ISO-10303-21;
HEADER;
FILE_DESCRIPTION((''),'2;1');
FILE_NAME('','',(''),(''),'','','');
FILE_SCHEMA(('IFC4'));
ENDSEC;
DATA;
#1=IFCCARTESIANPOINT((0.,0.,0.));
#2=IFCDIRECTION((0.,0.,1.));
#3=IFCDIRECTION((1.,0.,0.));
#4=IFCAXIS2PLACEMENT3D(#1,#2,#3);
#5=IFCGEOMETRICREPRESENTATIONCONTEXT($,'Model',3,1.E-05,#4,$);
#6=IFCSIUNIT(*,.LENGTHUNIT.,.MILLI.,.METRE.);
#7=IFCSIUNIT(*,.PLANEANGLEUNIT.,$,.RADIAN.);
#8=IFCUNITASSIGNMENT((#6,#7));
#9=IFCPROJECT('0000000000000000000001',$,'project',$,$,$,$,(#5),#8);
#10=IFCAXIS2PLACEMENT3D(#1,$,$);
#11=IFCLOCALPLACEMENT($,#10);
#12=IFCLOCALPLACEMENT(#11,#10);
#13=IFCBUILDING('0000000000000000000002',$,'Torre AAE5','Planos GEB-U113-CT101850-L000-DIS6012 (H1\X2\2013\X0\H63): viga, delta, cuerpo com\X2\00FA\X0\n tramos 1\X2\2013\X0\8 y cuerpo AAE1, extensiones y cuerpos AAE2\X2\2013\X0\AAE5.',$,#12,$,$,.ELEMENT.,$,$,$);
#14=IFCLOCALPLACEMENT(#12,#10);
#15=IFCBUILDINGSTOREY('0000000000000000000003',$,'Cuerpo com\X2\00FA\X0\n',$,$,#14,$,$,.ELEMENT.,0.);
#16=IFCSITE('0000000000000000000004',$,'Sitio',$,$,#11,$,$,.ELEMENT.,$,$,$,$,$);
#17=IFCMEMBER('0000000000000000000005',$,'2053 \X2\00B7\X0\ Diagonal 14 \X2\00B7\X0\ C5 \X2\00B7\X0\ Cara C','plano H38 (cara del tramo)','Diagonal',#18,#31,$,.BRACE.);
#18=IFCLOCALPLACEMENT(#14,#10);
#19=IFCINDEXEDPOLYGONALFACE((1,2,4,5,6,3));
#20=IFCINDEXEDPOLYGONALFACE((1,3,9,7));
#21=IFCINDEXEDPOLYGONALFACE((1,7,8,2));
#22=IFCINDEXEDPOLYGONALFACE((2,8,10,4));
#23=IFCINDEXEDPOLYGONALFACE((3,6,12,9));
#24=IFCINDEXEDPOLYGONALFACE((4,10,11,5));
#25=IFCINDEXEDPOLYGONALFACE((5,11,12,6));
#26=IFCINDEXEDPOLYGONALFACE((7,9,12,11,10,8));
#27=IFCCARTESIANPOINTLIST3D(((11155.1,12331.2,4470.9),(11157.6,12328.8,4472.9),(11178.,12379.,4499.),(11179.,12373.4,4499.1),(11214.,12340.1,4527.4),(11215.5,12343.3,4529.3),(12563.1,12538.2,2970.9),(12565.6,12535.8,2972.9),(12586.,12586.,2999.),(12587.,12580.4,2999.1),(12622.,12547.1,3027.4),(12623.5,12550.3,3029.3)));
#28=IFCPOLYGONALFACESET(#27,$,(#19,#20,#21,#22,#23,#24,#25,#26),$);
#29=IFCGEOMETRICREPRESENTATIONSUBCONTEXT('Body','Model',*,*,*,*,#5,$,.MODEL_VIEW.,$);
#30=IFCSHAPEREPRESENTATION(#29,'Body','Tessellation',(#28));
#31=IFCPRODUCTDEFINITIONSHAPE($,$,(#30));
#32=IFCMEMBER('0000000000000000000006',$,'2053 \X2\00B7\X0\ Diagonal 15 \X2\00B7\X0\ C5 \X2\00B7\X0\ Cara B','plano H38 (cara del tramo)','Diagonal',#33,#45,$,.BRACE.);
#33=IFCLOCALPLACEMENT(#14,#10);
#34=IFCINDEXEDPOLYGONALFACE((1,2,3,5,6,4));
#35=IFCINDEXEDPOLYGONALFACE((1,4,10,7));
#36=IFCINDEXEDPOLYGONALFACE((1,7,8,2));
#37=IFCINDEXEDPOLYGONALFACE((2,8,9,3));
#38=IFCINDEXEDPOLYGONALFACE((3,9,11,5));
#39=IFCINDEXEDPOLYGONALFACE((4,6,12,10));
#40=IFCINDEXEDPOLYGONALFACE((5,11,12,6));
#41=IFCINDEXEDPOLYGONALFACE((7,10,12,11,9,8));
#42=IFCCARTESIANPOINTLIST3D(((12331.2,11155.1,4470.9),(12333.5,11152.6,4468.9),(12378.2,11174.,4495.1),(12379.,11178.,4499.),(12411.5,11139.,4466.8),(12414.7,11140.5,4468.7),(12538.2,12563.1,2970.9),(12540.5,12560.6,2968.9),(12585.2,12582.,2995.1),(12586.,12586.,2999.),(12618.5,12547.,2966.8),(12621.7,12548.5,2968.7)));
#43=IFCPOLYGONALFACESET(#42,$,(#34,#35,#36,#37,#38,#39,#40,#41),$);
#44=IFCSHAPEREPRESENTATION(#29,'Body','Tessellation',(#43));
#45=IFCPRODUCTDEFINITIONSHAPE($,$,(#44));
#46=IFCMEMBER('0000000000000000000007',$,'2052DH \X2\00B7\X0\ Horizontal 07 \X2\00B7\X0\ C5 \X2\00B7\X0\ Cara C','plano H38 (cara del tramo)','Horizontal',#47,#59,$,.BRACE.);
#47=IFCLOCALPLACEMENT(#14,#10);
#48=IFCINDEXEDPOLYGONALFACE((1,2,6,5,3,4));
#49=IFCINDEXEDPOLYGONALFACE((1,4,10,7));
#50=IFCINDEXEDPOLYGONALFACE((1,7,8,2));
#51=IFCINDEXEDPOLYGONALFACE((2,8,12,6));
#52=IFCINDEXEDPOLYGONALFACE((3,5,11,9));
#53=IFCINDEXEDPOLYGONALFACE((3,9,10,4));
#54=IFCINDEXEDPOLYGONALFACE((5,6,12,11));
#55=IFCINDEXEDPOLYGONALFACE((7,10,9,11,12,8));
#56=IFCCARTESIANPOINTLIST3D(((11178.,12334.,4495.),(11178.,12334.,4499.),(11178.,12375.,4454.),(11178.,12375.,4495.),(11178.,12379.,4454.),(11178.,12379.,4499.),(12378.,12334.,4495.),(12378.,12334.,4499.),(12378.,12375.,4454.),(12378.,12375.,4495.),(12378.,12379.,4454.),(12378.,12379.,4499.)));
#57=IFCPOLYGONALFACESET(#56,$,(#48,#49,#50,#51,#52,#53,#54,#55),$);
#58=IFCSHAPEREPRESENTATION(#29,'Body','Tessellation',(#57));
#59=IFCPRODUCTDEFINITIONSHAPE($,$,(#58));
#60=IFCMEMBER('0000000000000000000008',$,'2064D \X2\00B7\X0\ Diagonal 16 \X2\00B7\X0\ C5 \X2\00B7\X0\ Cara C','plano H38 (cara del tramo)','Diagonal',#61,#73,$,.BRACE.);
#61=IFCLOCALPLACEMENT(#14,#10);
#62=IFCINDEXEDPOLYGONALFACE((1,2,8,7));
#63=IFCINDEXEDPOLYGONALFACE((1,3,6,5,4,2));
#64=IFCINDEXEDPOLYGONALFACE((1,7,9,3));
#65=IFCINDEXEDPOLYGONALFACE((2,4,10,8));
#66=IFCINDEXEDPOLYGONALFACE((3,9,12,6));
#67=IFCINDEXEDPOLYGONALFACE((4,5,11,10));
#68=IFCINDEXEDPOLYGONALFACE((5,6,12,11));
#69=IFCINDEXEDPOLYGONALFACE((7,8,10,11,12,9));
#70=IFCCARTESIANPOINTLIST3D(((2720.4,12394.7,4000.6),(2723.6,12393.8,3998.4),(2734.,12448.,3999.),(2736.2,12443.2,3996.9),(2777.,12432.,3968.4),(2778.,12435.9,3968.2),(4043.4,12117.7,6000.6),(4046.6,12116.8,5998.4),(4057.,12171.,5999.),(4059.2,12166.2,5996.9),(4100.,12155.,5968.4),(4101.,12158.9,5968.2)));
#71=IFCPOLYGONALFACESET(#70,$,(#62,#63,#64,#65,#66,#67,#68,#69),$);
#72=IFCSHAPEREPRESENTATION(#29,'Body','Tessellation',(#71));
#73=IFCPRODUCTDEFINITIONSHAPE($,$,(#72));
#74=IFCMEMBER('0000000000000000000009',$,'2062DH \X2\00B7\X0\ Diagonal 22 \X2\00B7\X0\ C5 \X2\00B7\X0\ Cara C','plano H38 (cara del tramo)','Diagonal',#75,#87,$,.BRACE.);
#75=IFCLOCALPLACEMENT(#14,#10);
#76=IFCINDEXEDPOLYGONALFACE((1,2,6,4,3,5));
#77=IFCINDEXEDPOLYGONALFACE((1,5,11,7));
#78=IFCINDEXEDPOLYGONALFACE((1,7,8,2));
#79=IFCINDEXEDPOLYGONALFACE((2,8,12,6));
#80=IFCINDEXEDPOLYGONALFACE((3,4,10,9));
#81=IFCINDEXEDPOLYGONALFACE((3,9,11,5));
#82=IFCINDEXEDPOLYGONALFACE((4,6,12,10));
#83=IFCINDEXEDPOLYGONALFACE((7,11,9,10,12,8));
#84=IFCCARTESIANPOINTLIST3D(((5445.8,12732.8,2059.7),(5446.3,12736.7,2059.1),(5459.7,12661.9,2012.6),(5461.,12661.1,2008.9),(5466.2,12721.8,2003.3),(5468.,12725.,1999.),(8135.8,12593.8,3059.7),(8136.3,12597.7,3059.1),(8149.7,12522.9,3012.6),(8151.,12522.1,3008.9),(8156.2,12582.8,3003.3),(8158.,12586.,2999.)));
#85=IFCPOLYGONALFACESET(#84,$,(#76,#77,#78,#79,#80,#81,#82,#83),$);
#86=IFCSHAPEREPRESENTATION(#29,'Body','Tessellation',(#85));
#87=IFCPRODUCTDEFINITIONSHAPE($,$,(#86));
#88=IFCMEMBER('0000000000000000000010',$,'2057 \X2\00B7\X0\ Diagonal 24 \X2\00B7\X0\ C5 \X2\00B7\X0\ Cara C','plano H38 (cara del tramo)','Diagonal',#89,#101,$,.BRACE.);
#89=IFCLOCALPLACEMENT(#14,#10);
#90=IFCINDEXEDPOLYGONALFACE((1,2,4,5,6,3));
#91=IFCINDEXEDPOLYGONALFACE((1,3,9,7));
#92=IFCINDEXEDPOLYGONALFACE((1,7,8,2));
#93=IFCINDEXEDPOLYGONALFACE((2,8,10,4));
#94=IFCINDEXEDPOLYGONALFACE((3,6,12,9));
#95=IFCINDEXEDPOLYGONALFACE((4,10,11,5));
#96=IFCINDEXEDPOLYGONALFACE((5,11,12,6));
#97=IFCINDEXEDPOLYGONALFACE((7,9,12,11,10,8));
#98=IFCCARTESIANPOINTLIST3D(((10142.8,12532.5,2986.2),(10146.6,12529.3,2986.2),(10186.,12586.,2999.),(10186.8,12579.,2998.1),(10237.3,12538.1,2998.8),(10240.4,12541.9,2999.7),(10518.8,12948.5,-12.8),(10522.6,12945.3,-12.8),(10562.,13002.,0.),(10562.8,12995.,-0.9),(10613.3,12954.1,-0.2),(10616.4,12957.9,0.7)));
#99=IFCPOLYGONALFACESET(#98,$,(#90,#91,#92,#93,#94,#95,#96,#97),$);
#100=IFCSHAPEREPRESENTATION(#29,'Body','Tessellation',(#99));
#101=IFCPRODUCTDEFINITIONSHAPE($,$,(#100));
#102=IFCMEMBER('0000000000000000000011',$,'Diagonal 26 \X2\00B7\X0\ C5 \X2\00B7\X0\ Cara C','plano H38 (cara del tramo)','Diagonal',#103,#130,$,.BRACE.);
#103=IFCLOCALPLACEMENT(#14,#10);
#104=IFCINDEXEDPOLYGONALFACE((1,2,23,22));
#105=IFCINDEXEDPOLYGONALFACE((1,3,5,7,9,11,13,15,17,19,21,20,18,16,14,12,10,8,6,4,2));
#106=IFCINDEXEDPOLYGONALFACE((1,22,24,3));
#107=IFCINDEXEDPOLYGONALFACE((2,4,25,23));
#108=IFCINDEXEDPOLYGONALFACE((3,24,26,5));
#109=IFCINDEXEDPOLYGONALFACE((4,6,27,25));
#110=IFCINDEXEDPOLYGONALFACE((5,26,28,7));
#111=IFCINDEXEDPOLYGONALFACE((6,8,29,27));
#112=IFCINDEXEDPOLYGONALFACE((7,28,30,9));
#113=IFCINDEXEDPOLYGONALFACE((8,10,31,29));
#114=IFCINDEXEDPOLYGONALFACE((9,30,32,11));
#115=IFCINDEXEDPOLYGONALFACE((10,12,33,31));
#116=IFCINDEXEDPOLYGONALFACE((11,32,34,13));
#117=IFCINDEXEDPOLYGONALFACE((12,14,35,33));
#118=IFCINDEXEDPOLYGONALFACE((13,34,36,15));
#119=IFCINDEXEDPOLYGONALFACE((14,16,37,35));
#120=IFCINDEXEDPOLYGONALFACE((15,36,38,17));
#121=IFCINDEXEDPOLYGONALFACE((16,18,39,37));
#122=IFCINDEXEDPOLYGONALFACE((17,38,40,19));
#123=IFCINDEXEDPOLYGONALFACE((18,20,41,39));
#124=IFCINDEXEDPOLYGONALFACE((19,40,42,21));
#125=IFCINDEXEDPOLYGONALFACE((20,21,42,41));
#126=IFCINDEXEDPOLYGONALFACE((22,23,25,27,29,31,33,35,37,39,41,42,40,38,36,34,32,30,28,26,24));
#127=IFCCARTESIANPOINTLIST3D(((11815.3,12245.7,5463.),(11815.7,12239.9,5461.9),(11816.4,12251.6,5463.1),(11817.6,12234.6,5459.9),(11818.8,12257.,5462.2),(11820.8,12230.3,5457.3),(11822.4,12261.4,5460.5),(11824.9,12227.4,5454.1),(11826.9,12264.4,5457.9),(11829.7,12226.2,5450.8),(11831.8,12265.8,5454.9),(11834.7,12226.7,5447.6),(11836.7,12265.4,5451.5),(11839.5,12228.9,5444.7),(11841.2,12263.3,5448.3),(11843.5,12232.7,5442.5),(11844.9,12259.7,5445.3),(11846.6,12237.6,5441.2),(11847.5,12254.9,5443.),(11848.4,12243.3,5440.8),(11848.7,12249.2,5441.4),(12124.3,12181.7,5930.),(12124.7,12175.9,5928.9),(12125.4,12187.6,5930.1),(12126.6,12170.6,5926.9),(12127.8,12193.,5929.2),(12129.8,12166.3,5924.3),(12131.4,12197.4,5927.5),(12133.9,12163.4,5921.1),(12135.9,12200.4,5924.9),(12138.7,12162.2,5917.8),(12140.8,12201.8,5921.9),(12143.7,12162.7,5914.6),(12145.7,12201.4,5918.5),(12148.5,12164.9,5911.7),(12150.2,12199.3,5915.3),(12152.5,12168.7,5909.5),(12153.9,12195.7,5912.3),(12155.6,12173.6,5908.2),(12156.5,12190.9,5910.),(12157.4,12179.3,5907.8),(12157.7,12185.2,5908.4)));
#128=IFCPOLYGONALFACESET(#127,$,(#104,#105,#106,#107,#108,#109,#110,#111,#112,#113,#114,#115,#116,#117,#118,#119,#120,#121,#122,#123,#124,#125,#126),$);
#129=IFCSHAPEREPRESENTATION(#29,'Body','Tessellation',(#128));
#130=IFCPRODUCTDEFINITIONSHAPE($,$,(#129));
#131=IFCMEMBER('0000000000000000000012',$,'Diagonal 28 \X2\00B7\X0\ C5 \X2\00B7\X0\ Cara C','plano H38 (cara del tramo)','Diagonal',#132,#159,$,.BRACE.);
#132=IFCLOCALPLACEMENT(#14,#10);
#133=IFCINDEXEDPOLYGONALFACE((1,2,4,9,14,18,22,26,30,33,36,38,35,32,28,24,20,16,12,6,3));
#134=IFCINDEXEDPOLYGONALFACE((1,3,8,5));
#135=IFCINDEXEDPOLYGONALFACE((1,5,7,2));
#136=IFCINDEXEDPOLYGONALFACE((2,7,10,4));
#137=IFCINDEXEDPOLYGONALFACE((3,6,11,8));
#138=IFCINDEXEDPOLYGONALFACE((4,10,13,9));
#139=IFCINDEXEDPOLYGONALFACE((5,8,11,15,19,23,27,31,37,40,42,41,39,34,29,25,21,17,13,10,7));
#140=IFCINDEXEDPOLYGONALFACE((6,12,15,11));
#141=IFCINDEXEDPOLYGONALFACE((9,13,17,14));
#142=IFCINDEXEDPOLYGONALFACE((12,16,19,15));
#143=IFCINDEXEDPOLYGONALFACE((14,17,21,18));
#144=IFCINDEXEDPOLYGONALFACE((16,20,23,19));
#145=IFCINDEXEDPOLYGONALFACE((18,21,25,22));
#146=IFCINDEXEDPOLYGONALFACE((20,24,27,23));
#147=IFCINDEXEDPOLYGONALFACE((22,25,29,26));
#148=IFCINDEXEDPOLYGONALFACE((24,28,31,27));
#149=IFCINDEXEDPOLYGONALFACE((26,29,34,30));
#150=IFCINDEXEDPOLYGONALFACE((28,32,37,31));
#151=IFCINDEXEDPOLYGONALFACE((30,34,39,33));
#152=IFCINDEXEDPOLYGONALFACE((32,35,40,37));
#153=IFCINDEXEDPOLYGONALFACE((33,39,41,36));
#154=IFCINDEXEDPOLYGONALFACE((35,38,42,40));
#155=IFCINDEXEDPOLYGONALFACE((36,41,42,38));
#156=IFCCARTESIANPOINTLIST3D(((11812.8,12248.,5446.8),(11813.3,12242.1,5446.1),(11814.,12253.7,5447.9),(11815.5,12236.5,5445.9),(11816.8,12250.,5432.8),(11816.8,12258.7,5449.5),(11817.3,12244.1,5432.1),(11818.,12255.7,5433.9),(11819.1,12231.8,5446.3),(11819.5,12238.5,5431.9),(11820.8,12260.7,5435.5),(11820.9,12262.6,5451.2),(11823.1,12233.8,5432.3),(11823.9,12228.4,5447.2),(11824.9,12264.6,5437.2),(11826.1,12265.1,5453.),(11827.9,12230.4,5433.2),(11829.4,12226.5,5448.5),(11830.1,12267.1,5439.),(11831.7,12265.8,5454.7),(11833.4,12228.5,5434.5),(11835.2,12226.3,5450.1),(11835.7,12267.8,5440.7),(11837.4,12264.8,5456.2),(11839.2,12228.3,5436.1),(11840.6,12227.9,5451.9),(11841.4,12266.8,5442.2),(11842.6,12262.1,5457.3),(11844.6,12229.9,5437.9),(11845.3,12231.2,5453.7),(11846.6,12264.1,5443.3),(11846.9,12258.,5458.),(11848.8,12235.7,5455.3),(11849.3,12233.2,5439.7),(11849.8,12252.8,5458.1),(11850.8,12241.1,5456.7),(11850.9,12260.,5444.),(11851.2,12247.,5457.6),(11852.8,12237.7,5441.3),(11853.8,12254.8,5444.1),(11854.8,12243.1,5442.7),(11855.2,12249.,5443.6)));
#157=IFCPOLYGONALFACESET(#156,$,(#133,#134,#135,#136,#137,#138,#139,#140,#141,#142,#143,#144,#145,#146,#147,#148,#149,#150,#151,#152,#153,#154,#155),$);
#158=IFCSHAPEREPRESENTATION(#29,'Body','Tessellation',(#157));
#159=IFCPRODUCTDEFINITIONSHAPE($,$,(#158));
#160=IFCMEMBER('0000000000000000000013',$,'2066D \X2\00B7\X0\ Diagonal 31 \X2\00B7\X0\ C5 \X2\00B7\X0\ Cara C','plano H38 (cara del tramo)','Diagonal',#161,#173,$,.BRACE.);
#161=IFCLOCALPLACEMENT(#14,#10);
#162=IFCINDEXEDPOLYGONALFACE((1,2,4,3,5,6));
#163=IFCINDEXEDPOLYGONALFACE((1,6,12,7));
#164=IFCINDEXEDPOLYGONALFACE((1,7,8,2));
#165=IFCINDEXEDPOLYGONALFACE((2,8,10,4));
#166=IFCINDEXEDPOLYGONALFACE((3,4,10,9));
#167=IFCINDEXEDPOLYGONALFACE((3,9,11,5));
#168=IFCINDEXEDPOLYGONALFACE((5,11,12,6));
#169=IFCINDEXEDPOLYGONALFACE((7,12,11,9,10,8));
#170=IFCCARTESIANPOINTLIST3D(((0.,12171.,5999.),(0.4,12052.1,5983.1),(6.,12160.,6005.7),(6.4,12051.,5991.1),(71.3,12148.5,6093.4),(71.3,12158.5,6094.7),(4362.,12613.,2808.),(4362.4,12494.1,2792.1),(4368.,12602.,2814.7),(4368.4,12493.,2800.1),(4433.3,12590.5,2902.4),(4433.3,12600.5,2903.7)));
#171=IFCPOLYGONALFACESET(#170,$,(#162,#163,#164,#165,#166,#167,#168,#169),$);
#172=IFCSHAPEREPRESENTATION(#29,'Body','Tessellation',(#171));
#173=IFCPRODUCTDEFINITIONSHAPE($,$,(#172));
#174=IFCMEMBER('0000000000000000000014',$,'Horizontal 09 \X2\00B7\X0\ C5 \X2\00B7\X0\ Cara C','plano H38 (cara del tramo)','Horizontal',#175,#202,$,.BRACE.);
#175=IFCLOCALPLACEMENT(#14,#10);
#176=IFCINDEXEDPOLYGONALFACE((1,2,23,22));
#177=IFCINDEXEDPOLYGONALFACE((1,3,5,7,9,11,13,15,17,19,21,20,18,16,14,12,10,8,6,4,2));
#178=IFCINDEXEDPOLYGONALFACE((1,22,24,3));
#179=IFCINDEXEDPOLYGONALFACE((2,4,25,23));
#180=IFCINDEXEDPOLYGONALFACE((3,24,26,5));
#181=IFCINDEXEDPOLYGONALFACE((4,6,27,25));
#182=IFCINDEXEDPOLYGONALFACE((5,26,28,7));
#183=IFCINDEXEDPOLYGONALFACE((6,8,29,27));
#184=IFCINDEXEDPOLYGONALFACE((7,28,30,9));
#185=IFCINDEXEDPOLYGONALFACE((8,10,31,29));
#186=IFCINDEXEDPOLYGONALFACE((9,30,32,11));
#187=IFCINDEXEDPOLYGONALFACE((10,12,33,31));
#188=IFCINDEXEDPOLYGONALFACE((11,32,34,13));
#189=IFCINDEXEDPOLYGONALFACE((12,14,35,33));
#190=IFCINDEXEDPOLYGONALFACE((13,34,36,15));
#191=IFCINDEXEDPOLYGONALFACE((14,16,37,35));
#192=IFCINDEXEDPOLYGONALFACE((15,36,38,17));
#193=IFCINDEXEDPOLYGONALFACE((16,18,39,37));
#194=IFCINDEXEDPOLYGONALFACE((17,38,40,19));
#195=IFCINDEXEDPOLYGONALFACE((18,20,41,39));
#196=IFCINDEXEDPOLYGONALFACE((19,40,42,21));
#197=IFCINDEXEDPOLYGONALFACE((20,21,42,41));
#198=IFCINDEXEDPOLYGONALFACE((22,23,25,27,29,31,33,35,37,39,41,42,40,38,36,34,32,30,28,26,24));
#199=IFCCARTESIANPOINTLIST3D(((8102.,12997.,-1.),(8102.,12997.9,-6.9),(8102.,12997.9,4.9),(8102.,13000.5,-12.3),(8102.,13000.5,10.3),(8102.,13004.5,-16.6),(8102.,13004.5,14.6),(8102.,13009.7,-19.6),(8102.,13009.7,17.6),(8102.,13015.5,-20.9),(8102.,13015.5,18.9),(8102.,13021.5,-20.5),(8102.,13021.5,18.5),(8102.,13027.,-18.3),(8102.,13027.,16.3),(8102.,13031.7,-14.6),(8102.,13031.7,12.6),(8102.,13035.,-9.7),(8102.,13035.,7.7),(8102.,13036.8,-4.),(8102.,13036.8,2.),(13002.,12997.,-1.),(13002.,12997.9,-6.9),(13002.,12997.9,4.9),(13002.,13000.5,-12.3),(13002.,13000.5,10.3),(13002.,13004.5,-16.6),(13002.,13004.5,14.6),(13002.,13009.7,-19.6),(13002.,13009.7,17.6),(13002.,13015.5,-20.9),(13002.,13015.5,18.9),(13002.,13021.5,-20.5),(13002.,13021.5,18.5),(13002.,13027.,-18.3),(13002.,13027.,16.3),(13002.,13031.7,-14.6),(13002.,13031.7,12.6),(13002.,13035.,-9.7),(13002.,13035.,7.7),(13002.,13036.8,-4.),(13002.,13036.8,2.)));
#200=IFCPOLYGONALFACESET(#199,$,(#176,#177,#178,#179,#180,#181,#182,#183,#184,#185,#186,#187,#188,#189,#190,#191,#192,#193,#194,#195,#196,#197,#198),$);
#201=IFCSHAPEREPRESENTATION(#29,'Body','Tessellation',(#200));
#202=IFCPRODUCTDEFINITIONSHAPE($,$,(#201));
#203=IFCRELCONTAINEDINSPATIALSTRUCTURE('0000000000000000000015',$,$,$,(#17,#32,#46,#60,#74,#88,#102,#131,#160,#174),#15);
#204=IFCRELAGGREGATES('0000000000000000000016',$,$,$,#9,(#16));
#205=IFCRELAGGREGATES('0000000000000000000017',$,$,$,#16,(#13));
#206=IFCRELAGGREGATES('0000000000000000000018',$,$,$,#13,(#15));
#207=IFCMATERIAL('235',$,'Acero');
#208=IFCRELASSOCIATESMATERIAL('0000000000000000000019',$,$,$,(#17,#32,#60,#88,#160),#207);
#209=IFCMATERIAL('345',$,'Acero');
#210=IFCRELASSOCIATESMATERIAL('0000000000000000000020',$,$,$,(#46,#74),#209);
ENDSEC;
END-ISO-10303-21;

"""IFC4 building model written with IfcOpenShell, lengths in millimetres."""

from ifc_helpers import new_model, si_unit, frame, frame_2d, origin, origin_with_axes, place, context, subcontext, project, spatial, circle, l_section, extrude, material, element, save


model = new_model("IFC4")

# Units and contexts
model_context = context("Model", 3, precision=1e-05, world=origin_with_axes())
body_context = subcontext(model_context, "Body", "Model", "MODEL_VIEW")
ifc_project = project(units=[si_unit("LENGTHUNIT", "METRE", prefix="MILLI"), si_unit("PLANEANGLEUNIT", "RADIAN")], contexts=[model_context])

# Site, building, storey
site_placement = place(None, origin())
site = spatial("IfcSite", under=ifc_project, at=site_placement, Name="Sitio", CompositionType="ELEMENT")
building_placement = place(site_placement, origin())
building = spatial("IfcBuilding", under=site, at=building_placement, Name="Torre AAE5", Description="Planos GEB-U113-CT101850-L000-DIS6012 (H1–H63): viga, delta, cuerpo común tramos 1–8 y cuerpo AAE1, extensiones y cuerpos AAE2–AAE5.", CompositionType="ELEMENT")
storey_placement = place(building_placement, origin())
storey = spatial("IfcBuildingStorey", under=building, at=storey_placement, Name="Cuerpo común", CompositionType="ELEMENT", Elevation=0.0)

# Members
ifc_material_1 = material(Name="345", Category="Acero")
ifc_material_2 = material(Name="235", Category="Acero")
for number, where, z_axis, x_axis, name in (
    (1, (12586.0, 12586.0, 2999.0), (-0.680955, -0.100112, 0.72545), (-0.381242, -0.797329, -0.46789), "2053 · Diagonal 14 · C5 · Cara C"),
    (2, (12586.0, 12586.0, 2999.0), (-0.100112, -0.680955, 0.72545), (-0.797329, -0.381242, -0.46789), "2053 · Diagonal 15 · C5 · Cara B"),
):
    element("IfcMember", number, at=place(storey_placement, frame(where, z_axis=z_axis, x_axis=x_axis)), inside=storey, material=ifc_material_2, Name=name, Description="plano H38 (cara del tramo)", ObjectType="Diagonal", PredefinedType="BRACE", context=body_context, shape_type="SweptSolid", body=[
        extrude(l_section(Depth=60.0, Width=60.0, Thickness=4.0, at=frame_2d((30.0, 30.0))), None, (0.0, 0.0, 1.0), 2067.7),
    ])
member_1_placement = place(storey_placement, frame((11178.0, 12379.0, 4499.0), z_axis=(1.0, 0.0, 0.0), x_axis=(0.0, -1.0, 0.0)))
element("IfcMember", 3, at=member_1_placement, inside=storey, material=ifc_material_1, Name="2052DH · Horizontal 07 · C5 · Cara C", Description="plano H38 (cara del tramo)", ObjectType="Horizontal", PredefinedType="BRACE", context=body_context, shape_type="SweptSolid", body=[
    extrude(l_section(Depth=45.0, Width=45.0, Thickness=4.0, at=frame_2d((22.5, 22.5))), None, (0.0, 0.0, 1.0), 1200.0),
])
member_2_placement = place(storey_placement, frame((2734.0, 12448.0, 3999.0), z_axis=(0.548069, -0.114751, 0.828524), x_axis=(-0.246817, -0.968625, 0.029115)))
element("IfcMember", 4, at=member_2_placement, inside=storey, material=ifc_material_2, Name="2064D · Diagonal 16 · C5 · Cara C", Description="plano H38 (cara del tramo)", ObjectType="Diagonal", PredefinedType="BRACE", context=body_context, shape_type="SweptSolid", body=[
    extrude(l_section(Depth=55.0, Width=55.0, Thickness=4.0, at=frame_2d((27.5, 27.5))), None, (0.0, 0.0, 1.0), 2413.9),
])
member_3_placement = place(storey_placement, frame((8158.0, 12586.0, 2999.0), z_axis=(-0.93623, 0.048378, -0.348041), x_axis=(-0.107435, -0.982456, 0.152438)))
element("IfcMember", 5, at=member_3_placement, inside=storey, material=ifc_material_1, Name="2062DH · Diagonal 22 · C5 · Cara C", Description="plano H38 (cara del tramo)", ObjectType="Diagonal", PredefinedType="BRACE", context=body_context, shape_type="SweptSolid", body=[
    extrude(l_section(Depth=65.0, Width=65.0, Thickness=4.0, at=frame_2d((32.5, 32.5))), None, (0.0, 0.0, 1.0), 2873.2),
])
member_4_placement = place(storey_placement, frame((10562.0, 13002.0, 0.0), z_axis=(-0.123239, -0.13635, 0.982965), x_axis=(-0.617694, -0.764706, -0.183518)))
element("IfcMember", 6, at=member_4_placement, inside=storey, material=ifc_material_2, Name="2057 · Diagonal 24 · C5 · Cara C", Description="plano H38 (cara del tramo)", ObjectType="Diagonal", PredefinedType="BRACE", context=body_context, shape_type="SweptSolid", body=[
    extrude(l_section(Depth=70.0, Width=70.0, Thickness=5.0, at=frame_2d((35.0, 35.0))), None, (0.0, 0.0, 1.0), 3051.0),
])
member_5_placement = place(storey_placement, frame((12141.0, 12182.0, 5919.0), z_axis=(-0.548243, 0.113552, -0.828574), x_axis=(-0.560683, -0.785018, 0.263405)))
element("IfcMember", 7, at=member_5_placement, inside=storey, Name="Diagonal 26 · C5 · Cara C", Description="plano H38 (cara del tramo)", ObjectType="Diagonal", PredefinedType="BRACE", context=body_context, shape_type="SweptSolid", body=[
    extrude(circle(Radius=20.0), None, (0.0, 0.0, 1.0), 563.6),
])
member_6_placement = place(storey_placement, frame((11832.0, 12246.0, 5452.0), z_axis=(0.272166, 0.136083, -0.952579), x_axis=(-0.643854, -0.709938, -0.285378)))
element("IfcMember", 8, at=member_6_placement, inside=storey, Name="Diagonal 28 · C5 · Cara C", Description="plano H38 (cara del tramo)", ObjectType="Diagonal", PredefinedType="BRACE", context=body_context, shape_type="SweptSolid", body=[
    extrude(circle(Radius=20.0), None, (0.0, 0.0, 1.0), 14.7),
])
member_7_placement = place(storey_placement, frame((4362.0, 12613.0, 2808.0), z_axis=(-0.804407, -0.08151, 0.58846), x_axis=(0.003485, -0.991173, -0.132529)))
element("IfcMember", 9, at=member_7_placement, inside=storey, material=ifc_material_2, Name="2066D · Diagonal 31 · C5 · Cara C", Description="plano H38 (cara del tramo)", ObjectType="Diagonal", PredefinedType="BRACE", context=body_context, shape_type="SweptSolid", body=[
    extrude(l_section(Depth=120.0, Width=120.0, Thickness=10.0, at=frame_2d((60.0, 60.0))), None, (0.0, 0.0, 1.0), 5422.6),
])
for number, where, z_axis, x_axis, name in (
    (10, (13002.0, 13017.0, -1.0), (-1.0, 0.0, 0.0), (0.0, -1.0, 0.0), "Horizontal 09 · C5 · Cara C"),
):
    element("IfcMember", number, at=place(storey_placement, frame(where, z_axis=z_axis, x_axis=x_axis)), inside=storey, Name=name, Description="plano H38 (cara del tramo)", ObjectType="Horizontal", PredefinedType="BRACE", context=body_context, shape_type="SweptSolid", body=[
        extrude(circle(Radius=20.0), None, (0.0, 0.0, 1.0), 4900.0),
    ])

save(model, "model.ifc")
